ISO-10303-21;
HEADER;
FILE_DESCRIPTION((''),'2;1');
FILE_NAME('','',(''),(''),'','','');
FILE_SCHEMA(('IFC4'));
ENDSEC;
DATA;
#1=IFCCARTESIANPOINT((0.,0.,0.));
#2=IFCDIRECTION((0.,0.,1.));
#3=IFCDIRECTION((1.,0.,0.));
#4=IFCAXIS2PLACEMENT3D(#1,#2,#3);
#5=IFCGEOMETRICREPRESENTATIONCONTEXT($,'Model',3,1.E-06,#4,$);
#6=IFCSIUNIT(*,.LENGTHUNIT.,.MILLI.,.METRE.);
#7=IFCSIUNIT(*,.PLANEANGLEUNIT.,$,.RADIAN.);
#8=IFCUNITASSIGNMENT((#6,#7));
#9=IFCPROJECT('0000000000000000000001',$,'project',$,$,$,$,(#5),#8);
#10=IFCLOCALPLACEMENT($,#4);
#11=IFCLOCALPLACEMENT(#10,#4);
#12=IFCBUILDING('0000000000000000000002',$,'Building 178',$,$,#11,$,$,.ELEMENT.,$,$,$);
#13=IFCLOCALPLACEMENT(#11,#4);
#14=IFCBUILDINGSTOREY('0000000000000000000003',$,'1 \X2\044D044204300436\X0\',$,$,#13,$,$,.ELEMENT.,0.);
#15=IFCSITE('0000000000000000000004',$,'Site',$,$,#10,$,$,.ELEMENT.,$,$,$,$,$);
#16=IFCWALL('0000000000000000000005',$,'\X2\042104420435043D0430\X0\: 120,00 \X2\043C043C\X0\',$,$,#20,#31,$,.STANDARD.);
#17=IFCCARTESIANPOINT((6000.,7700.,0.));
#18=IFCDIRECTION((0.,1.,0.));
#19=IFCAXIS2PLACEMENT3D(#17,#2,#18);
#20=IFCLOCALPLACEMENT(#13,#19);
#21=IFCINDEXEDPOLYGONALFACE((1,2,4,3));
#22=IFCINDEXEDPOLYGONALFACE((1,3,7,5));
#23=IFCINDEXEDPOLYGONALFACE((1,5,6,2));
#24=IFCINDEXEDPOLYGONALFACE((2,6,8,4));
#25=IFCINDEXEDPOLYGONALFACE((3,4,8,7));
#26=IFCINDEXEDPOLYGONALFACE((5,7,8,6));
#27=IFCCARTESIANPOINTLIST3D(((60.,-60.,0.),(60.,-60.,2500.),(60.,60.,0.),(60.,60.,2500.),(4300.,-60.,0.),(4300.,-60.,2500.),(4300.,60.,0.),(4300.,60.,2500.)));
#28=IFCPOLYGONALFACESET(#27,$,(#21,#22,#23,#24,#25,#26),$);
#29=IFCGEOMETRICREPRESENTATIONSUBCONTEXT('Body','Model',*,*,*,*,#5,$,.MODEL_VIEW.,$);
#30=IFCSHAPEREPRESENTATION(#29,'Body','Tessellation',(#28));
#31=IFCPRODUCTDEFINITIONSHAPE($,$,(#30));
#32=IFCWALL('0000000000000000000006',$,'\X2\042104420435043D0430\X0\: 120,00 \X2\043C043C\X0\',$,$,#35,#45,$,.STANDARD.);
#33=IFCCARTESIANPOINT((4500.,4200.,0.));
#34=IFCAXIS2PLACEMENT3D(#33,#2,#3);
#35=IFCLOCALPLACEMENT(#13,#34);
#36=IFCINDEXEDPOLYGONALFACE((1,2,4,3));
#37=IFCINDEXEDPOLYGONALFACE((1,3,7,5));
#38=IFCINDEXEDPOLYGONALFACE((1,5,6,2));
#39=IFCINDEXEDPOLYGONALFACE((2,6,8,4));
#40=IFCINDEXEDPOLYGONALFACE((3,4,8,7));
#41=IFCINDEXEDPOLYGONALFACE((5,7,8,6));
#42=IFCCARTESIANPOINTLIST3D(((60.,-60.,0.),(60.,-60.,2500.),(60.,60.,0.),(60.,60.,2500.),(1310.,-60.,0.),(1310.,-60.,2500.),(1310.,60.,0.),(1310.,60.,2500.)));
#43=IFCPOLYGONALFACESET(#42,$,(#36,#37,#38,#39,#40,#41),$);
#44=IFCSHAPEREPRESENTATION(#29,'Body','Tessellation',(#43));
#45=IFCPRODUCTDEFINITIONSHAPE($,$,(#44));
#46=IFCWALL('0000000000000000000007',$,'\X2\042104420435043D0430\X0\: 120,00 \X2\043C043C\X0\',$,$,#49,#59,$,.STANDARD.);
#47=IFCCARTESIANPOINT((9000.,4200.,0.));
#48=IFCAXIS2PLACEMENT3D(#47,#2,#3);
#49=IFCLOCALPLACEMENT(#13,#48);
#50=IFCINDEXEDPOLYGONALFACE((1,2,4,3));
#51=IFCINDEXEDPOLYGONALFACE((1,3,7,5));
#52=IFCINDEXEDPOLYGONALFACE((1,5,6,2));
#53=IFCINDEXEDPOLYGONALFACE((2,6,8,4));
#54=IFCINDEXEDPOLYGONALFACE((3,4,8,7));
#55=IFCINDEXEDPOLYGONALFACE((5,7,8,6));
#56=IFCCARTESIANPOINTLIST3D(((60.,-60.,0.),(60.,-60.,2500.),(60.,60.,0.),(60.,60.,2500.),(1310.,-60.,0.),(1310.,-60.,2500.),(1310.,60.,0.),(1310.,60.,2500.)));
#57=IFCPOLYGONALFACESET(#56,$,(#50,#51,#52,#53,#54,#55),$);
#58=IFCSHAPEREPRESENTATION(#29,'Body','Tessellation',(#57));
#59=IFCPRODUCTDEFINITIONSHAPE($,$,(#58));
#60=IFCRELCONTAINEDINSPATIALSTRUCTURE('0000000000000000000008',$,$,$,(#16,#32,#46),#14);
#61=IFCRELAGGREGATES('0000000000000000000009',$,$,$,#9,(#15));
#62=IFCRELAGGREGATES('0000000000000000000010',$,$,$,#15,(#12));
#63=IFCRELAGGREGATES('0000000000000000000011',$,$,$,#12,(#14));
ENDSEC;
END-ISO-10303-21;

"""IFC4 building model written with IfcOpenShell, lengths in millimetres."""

from ifc_helpers import new_model, si_unit, frame, origin_with_axes, place, context, subcontext, project, spatial, line, indexed_curve, outline, extrude, source, transform, mapped, element, save


model = new_model("IFC4")

# Units and contexts
model_context = context("Model", 3, precision=1e-06, world=origin_with_axes())
body_context = subcontext(model_context, "Body", "Model", "MODEL_VIEW")
ifc_project = project(units=[si_unit("LENGTHUNIT", "METRE", prefix="MILLI"), si_unit("PLANEANGLEUNIT", "RADIAN")], contexts=[model_context])

# Site, building, storey
site_placement = place(None, origin_with_axes())
site = spatial("IfcSite", under=ifc_project, at=site_placement, Name="Site", CompositionType="ELEMENT")
building_placement = place(site_placement, origin_with_axes())
building = spatial("IfcBuilding", under=site, at=building_placement, Name="Building 178", CompositionType="ELEMENT")
storey_placement = place(building_placement, origin_with_axes())
storey = spatial("IfcBuildingStorey", under=building, at=storey_placement, Name="1 этаж", CompositionType="ELEMENT", Elevation=0.0)

# Walls
shared_shape_1 = source(origin_with_axes(), body_context, "Body", "SweptSolid", [
    extrude(outline(indexed_curve([(60.0, -60.0), (4300.0, -60.0), (4300.0, 60.0), (60.0, 60.0)], segments=[line(1, 2), line(2, 3), line(3, 4), line(4, 1)])), origin_with_axes(), (0.0, 0.0, 1.0), 2500.0),
])
wall_1_placement = place(storey_placement, frame((6000.0, 7700.0, 0.0), z_axis=(0.0, 0.0, 1.0), x_axis=(0.0, 1.0, 0.0)))
element("IfcWall", 1, at=wall_1_placement, inside=storey, Name="Стена: 120,00 мм", PredefinedType="STANDARD", context=body_context, shape_type="MappedRepresentation", body=[
    mapped(shared_shape_1, transform((0.0, 0.0, 0.0), x_axis=(1.0, 0.0, 0.0), y_axis=(0.0, 1.0, 0.0), z_axis=(0.0, 0.0, 1.0), scale=1.0)),
])
shared_shape_2 = source(origin_with_axes(), body_context, "Body", "SweptSolid", [
    extrude(outline(indexed_curve([(60.0, -60.0), (1310.0, -60.0), (1310.0, 60.0), (60.0, 60.0)], segments=[line(1, 2), line(2, 3), line(3, 4), line(4, 1)])), origin_with_axes(), (0.0, 0.0, 1.0), 2500.0),
])
for number, where, z_axis, x_axis, name in (
    (2, (4500.0, 4200.0, 0.0), (0.0, 0.0, 1.0), (1.0, 0.0, 0.0), "Стена: 120,00 мм"),
    (3, (9000.0, 4200.0, 0.0), (0.0, 0.0, 1.0), (1.0, 0.0, 0.0), "Стена: 120,00 мм"),
):
    element("IfcWall", number, at=place(storey_placement, frame(where, z_axis=z_axis, x_axis=x_axis)), inside=storey, Name=name, PredefinedType="STANDARD", context=body_context, shape_type="MappedRepresentation", body=[
        mapped(shared_shape_2, transform((0.0, 0.0, 0.0), x_axis=(1.0, 0.0, 0.0), y_axis=(0.0, 1.0, 0.0), z_axis=(0.0, 0.0, 1.0), scale=1.0)),
    ])

save(model, "model.ifc")
